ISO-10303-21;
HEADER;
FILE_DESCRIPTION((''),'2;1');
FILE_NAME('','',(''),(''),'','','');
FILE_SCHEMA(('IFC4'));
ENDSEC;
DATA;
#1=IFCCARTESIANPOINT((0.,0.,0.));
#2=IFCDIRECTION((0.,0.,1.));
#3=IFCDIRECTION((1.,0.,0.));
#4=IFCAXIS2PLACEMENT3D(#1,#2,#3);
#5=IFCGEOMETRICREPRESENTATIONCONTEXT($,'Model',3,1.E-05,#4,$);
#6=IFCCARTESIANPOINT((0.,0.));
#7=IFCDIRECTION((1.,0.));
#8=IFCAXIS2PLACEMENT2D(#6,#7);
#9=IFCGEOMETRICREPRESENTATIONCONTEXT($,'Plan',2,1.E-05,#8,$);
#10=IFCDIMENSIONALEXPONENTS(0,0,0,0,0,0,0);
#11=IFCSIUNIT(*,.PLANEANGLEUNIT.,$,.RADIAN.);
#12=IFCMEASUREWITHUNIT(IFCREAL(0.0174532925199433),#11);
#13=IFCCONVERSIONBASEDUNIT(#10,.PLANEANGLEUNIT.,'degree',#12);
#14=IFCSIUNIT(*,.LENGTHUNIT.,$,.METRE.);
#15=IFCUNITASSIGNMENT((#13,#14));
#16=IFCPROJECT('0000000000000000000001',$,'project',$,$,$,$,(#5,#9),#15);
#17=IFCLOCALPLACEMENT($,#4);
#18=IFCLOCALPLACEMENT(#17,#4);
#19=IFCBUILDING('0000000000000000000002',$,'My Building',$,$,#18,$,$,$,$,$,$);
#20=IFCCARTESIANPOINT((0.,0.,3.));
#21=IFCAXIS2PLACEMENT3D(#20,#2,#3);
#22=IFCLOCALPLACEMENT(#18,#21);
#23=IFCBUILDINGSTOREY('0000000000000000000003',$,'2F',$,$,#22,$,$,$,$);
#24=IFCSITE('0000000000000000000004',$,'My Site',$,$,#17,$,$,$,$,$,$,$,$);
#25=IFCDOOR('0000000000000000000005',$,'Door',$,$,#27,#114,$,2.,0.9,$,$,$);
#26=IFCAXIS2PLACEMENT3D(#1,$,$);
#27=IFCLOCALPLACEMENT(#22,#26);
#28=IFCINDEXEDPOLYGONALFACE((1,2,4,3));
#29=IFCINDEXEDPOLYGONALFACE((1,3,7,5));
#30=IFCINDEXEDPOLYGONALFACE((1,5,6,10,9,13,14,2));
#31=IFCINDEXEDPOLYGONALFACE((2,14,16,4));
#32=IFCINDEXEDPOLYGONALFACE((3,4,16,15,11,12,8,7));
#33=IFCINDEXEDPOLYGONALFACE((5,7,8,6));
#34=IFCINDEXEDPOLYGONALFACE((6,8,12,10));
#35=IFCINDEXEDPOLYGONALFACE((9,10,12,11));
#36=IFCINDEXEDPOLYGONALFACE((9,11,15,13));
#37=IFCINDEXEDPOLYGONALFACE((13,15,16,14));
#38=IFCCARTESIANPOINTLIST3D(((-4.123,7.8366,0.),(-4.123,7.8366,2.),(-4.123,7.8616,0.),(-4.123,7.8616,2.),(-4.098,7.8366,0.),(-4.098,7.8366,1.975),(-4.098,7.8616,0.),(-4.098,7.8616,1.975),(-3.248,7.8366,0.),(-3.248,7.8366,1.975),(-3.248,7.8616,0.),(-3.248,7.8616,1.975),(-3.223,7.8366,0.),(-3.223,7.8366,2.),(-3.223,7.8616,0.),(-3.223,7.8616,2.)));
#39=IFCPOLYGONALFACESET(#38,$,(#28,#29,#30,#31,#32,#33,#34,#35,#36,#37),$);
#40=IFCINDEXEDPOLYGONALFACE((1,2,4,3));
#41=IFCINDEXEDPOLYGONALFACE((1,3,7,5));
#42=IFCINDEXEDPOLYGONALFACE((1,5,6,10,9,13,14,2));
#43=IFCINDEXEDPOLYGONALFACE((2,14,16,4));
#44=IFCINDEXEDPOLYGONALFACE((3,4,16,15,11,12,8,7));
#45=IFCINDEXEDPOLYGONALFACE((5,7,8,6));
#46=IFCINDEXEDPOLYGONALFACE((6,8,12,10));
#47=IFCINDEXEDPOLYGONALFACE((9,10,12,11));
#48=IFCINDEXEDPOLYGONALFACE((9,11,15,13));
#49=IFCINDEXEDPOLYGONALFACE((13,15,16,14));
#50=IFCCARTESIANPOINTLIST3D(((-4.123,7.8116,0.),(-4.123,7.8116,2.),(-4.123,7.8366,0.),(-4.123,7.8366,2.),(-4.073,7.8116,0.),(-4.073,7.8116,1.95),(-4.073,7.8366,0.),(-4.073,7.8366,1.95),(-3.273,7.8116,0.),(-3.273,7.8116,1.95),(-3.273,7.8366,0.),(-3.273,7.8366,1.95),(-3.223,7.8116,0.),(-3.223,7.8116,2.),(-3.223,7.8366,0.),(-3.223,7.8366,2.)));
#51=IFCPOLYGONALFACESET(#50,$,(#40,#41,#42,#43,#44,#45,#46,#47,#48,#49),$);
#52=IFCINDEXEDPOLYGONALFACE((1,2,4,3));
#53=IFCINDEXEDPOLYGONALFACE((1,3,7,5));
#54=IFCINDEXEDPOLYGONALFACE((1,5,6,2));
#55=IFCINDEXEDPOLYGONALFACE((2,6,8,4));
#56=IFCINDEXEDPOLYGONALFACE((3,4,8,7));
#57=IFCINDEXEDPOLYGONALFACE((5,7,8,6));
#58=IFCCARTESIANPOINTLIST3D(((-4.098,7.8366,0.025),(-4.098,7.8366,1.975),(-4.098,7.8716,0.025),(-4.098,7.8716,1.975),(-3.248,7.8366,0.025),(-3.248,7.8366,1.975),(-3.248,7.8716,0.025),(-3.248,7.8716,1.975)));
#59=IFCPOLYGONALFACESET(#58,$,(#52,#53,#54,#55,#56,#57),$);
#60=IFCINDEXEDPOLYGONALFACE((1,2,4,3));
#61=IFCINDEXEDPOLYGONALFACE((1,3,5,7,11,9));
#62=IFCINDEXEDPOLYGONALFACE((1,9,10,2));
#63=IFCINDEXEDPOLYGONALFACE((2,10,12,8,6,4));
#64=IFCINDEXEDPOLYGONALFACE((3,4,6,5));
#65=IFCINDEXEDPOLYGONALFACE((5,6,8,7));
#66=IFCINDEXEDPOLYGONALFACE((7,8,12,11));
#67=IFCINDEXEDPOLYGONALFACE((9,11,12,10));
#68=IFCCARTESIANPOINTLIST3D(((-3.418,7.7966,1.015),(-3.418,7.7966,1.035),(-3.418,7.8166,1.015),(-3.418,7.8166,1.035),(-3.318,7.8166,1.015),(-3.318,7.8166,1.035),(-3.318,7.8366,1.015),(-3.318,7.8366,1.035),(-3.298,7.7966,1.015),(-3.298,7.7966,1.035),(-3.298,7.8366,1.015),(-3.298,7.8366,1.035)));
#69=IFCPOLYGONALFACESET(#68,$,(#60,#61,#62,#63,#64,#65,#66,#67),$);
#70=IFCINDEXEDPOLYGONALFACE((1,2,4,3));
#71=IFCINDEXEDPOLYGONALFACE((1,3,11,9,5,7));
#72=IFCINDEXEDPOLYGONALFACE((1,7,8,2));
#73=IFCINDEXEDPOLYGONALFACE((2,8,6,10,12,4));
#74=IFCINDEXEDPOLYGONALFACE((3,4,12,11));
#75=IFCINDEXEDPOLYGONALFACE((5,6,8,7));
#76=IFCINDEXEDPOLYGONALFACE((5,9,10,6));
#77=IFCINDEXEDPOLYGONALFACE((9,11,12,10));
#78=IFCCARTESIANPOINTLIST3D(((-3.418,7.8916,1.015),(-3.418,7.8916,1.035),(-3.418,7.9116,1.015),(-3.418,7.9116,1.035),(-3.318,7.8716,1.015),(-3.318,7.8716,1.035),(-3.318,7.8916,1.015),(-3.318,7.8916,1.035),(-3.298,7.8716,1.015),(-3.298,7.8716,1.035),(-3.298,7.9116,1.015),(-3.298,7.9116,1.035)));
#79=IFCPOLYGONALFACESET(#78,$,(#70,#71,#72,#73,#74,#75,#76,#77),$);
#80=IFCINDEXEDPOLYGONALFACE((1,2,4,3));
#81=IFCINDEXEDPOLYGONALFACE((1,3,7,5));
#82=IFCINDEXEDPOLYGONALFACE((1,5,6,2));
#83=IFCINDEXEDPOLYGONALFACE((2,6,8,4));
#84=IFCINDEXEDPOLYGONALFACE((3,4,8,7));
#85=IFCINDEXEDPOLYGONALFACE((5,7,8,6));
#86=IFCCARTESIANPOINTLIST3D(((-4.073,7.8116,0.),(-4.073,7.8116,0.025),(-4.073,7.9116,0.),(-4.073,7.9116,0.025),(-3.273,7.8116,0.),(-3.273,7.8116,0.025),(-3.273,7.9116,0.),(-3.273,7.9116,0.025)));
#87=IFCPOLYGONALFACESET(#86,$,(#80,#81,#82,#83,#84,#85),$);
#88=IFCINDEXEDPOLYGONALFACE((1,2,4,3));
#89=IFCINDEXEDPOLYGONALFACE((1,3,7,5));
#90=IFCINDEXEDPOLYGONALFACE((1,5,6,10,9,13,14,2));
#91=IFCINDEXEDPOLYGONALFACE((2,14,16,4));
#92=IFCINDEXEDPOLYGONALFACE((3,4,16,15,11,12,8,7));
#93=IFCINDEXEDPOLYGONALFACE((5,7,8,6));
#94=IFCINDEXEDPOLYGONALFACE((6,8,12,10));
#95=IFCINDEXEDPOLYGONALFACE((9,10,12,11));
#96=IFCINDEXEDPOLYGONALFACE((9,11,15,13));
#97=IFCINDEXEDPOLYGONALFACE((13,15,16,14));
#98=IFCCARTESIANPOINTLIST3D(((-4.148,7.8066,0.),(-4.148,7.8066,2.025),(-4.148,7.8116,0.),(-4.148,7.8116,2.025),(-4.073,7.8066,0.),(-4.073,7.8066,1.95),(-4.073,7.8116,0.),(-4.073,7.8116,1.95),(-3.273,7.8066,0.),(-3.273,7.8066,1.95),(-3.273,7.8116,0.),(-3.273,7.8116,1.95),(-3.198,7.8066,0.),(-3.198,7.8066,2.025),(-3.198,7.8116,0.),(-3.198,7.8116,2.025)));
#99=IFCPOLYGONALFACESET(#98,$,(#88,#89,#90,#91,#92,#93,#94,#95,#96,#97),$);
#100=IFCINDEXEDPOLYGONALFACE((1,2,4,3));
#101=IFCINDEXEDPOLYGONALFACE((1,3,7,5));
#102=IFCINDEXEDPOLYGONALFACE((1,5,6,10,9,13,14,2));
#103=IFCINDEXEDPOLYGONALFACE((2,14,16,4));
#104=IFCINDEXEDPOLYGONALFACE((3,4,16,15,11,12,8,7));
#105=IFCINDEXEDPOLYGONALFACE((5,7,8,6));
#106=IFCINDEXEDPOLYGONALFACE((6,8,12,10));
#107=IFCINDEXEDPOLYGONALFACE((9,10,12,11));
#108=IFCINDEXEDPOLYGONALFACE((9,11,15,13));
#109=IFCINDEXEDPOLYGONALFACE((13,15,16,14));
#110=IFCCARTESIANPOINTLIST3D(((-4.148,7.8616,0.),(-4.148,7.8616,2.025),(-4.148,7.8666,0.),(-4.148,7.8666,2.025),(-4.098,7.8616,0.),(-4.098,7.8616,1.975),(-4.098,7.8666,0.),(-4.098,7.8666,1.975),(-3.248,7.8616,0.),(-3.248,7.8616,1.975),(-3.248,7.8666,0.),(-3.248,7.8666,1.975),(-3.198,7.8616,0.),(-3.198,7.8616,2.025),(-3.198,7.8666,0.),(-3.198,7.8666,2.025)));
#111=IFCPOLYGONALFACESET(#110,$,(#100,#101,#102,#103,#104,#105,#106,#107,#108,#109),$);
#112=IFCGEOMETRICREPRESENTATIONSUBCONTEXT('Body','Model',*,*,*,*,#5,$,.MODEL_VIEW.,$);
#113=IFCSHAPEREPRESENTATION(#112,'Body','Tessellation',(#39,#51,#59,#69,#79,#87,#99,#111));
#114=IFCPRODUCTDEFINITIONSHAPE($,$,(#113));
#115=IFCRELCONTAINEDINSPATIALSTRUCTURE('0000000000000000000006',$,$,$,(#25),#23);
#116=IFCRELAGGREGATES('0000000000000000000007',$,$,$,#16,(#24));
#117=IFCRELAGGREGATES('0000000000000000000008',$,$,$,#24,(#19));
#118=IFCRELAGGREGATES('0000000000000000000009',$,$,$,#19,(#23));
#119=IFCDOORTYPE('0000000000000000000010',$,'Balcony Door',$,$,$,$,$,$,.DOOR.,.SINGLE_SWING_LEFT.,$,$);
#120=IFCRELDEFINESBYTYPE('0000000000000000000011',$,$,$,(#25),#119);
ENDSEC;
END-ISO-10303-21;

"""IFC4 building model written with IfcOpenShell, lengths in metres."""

from ifc_helpers import new_model, entity, si_unit, converted_unit, frame, origin_with_axes, origin_2d_with_axis, place, context, subcontext, project, spatial, line, indexed_curve, outline, extrude, shape, source, transform, mapped, type_object, type_shapes, element, save


model = new_model("IFC4")

# Units and contexts
model_context = context("Model", 3, precision=1e-05, world=origin_with_axes())
plan_context = context("Plan", 2, precision=1e-05, world=origin_2d_with_axis())
body_context_1 = subcontext(model_context, "Body", "Model", "MODEL_VIEW")
body_context_2 = subcontext(plan_context, "Body", "Plan", "PLAN_VIEW")
ifc_project = project(units=[converted_unit("PLANEANGLEUNIT", "degree", entity("IfcReal", 0.0174532925199433), si_unit("PLANEANGLEUNIT", "RADIAN"), dimensions=[0, 0, 0, 0, 0, 0, 0]), si_unit("LENGTHUNIT", "METRE")], contexts=[model_context, plan_context])

# Site, building, storey
site_placement = place(None, origin_with_axes())
site = spatial("IfcSite", under=ifc_project, at=site_placement, Name="My Site")
building_placement = place(site_placement, origin_with_axes())
building = spatial("IfcBuilding", under=site, at=building_placement, Name="My Building")
storey_placement = place(building_placement, frame((0.0, 0.0, 3.0), z_axis=(0.0, 0.0, 1.0), x_axis=(1.0, 0.0, 0.0)))
storey = spatial("IfcBuildingStorey", under=building, at=storey_placement, Name="2F")

# Door
door_type_1 = type_object("IfcDoorType", Name="Balcony Door", OperationType="SINGLE_SWING_LEFT", PredefinedType="DOOR")
shared_shape_1 = source(origin_with_axes(), body_context_1, "Body", "SweptSolid", [
    extrude(outline(indexed_curve([(0.0, 0.0), (0.0, 2.0), (0.9, 2.0), (0.9, 0.0), (0.875, 0.0), (0.875, 1.975), (0.025, 1.975), (0.025, 0.0)], segments=[line(1, 2, 3, 4, 5, 6, 7, 8, 1)])), frame((0.0, 0.025, 0.0), z_axis=(0.0, -1.0, 0.0), x_axis=(1.0, 0.0, 0.0)), (0.0, 0.0, -1.0), 0.025),
    extrude(outline(indexed_curve([(0.0, 0.0), (0.0, 2.0), (0.9, 2.0), (0.9, 0.0), (0.85, 0.0), (0.85, 1.95), (0.05, 1.95), (0.05, 0.0)], segments=[line(1, 2, 3, 4, 5, 6, 7, 8, 1)])), frame((0.0, 0.0, 0.0), z_axis=(0.0, -1.0, 0.0), x_axis=(1.0, 0.0, 0.0)), (0.0, 0.0, -1.0), 0.025),
    extrude(outline(indexed_curve([(0.0, 0.0), (0.85, 0.0), (0.85, 0.035), (0.0, 0.035)], segments=[line(1, 2, 3, 4, 1)])), frame((0.025, 0.025, 0.025), z_axis=(0.0, 0.0, 1.0), x_axis=(1.0, 0.0, 0.0)), (0.0, 0.0, 1.0), 1.95),
    extrude(outline(indexed_curve([(0.0, 0.0), (0.0, -0.04), (-0.12, -0.04), (-0.12, -0.02), (-0.02, -0.02), (-0.02, 0.0)], segments=[line(1, 2, 3, 4, 5, 6, 1)])), frame((0.825, 0.025, 1.015), z_axis=(0.0, 0.0, 1.0), x_axis=(1.0, 0.0, 0.0)), (0.0, 0.0, 1.0), 0.02),
    extrude(outline(indexed_curve([(0.0, 0.0), (0.0, 0.04), (-0.12, 0.04), (-0.12, 0.02), (-0.02, 0.02), (-0.02, 0.0)], segments=[line(1, 2, 3, 4, 5, 6, 1)])), frame((0.825, 0.06, 1.015), z_axis=(0.0, 0.0, 1.0), x_axis=(1.0, 0.0, 0.0)), (0.0, 0.0, 1.0), 0.02),
    extrude(outline(indexed_curve([(0.0, 0.0), (0.8, 0.0), (0.8, 0.1), (0.0, 0.1)], segments=[line(1, 2, 3, 4, 1)])), frame((0.05, 0.0, 0.0), z_axis=(0.0, 0.0, 1.0), x_axis=(1.0, 0.0, 0.0)), (0.0, 0.0, 1.0), 0.025),
    extrude(outline(indexed_curve([(0.0, 0.0), (0.0, 2.025), (0.95, 2.025), (0.95, 0.0), (0.875, 0.0), (0.875, 1.95), (0.075, 1.95), (0.075, 0.0)], segments=[line(1, 2, 3, 4, 5, 6, 7, 8, 1)])), frame((-0.025, -0.005, 0.0), z_axis=(0.0, -1.0, 0.0), x_axis=(1.0, 0.0, 0.0)), (0.0, 0.0, -1.0), 0.005),
    extrude(outline(indexed_curve([(0.0, 0.0), (0.0, 2.025), (0.95, 2.025), (0.95, 0.0), (0.9, 0.0), (0.9, 1.975), (0.05, 1.975), (0.05, 0.0)], segments=[line(1, 2, 3, 4, 5, 6, 7, 8, 1)])), frame((-0.025, 0.05, 0.0), z_axis=(0.0, -1.0, 0.0), x_axis=(1.0, 0.0, 0.0)), (0.0, 0.0, -1.0), 0.005),
])
shared_shape_2 = source(origin_with_axes(), body_context_2, "Body", "Curve2D", [
    entity("IfcIndexedPolyCurve", entity("IfcCartesianPointList2D", [[0.0, 0.0], [0.0, 0.05], [0.025, 0.05], [0.025, 0.025], [0.05, 0.025], [0.05, 0.0]]), [entity("IfcLineIndex", [1, 2, 3, 4, 5, 6, 1])]),
    entity("IfcIndexedPolyCurve", entity("IfcCartesianPointList2D", [[0.9, 0.0], [0.9, 0.05], [0.875, 0.05], [0.875, 0.025], [0.85, 0.025], [0.85, 0.0]]), [entity("IfcLineIndex", [1, 2, 3, 4, 5, 6, 1])]),
    entity("IfcTrimmedCurve", entity("IfcEllipse", entity("IfcAxis2Placement2D", entity("IfcCartesianPoint", [0.06, 0.05]), entity("IfcDirection", [1.0, 0.0])), 0.815, 0.85), [entity("IfcCartesianPoint", [0.875, 0.05])], [entity("IfcCartesianPoint", [0.06, 0.9])], True, "CARTESIAN"),
    entity("IfcIndexedPolyCurve", entity("IfcCartesianPointList2D", [[0.025, 0.05], [0.06, 0.05], [0.06, 0.9], [0.025, 0.9]]), [entity("IfcLineIndex", [1, 2, 3, 4, 1])]),
])
type_shapes(door_type_1, [shared_shape_1, shared_shape_2])
door_1_placement = place(storey_placement, frame((-4.123, 7.8116, 0.0), z_axis=(0.0, 0.0, 1.0), x_axis=(1.0, 0.0, 0.0)))
element("IfcDoor", 1, at=door_1_placement, inside=storey, type_object=door_type_1, Name="Door", OverallHeight=2.0, OverallWidth=0.9, shapes=[
    shape(body_context_1, "Body", "MappedRepresentation", [mapped(shared_shape_1, transform((0.0, 0.0, 0.0), x_axis=(1.0, 0.0, 0.0), y_axis=(0.0, 1.0, 0.0), z_axis=(0.0, 0.0, 1.0), scale=1.0))]),
    shape(body_context_2, "Body", "MappedRepresentation", [mapped(shared_shape_2, transform((0.0, 0.0, 0.0), x_axis=(1.0, 0.0, 0.0), y_axis=(0.0, 1.0, 0.0), z_axis=(0.0, 0.0, 1.0), scale=1.0))]),
])

save(model, "model.ifc")
